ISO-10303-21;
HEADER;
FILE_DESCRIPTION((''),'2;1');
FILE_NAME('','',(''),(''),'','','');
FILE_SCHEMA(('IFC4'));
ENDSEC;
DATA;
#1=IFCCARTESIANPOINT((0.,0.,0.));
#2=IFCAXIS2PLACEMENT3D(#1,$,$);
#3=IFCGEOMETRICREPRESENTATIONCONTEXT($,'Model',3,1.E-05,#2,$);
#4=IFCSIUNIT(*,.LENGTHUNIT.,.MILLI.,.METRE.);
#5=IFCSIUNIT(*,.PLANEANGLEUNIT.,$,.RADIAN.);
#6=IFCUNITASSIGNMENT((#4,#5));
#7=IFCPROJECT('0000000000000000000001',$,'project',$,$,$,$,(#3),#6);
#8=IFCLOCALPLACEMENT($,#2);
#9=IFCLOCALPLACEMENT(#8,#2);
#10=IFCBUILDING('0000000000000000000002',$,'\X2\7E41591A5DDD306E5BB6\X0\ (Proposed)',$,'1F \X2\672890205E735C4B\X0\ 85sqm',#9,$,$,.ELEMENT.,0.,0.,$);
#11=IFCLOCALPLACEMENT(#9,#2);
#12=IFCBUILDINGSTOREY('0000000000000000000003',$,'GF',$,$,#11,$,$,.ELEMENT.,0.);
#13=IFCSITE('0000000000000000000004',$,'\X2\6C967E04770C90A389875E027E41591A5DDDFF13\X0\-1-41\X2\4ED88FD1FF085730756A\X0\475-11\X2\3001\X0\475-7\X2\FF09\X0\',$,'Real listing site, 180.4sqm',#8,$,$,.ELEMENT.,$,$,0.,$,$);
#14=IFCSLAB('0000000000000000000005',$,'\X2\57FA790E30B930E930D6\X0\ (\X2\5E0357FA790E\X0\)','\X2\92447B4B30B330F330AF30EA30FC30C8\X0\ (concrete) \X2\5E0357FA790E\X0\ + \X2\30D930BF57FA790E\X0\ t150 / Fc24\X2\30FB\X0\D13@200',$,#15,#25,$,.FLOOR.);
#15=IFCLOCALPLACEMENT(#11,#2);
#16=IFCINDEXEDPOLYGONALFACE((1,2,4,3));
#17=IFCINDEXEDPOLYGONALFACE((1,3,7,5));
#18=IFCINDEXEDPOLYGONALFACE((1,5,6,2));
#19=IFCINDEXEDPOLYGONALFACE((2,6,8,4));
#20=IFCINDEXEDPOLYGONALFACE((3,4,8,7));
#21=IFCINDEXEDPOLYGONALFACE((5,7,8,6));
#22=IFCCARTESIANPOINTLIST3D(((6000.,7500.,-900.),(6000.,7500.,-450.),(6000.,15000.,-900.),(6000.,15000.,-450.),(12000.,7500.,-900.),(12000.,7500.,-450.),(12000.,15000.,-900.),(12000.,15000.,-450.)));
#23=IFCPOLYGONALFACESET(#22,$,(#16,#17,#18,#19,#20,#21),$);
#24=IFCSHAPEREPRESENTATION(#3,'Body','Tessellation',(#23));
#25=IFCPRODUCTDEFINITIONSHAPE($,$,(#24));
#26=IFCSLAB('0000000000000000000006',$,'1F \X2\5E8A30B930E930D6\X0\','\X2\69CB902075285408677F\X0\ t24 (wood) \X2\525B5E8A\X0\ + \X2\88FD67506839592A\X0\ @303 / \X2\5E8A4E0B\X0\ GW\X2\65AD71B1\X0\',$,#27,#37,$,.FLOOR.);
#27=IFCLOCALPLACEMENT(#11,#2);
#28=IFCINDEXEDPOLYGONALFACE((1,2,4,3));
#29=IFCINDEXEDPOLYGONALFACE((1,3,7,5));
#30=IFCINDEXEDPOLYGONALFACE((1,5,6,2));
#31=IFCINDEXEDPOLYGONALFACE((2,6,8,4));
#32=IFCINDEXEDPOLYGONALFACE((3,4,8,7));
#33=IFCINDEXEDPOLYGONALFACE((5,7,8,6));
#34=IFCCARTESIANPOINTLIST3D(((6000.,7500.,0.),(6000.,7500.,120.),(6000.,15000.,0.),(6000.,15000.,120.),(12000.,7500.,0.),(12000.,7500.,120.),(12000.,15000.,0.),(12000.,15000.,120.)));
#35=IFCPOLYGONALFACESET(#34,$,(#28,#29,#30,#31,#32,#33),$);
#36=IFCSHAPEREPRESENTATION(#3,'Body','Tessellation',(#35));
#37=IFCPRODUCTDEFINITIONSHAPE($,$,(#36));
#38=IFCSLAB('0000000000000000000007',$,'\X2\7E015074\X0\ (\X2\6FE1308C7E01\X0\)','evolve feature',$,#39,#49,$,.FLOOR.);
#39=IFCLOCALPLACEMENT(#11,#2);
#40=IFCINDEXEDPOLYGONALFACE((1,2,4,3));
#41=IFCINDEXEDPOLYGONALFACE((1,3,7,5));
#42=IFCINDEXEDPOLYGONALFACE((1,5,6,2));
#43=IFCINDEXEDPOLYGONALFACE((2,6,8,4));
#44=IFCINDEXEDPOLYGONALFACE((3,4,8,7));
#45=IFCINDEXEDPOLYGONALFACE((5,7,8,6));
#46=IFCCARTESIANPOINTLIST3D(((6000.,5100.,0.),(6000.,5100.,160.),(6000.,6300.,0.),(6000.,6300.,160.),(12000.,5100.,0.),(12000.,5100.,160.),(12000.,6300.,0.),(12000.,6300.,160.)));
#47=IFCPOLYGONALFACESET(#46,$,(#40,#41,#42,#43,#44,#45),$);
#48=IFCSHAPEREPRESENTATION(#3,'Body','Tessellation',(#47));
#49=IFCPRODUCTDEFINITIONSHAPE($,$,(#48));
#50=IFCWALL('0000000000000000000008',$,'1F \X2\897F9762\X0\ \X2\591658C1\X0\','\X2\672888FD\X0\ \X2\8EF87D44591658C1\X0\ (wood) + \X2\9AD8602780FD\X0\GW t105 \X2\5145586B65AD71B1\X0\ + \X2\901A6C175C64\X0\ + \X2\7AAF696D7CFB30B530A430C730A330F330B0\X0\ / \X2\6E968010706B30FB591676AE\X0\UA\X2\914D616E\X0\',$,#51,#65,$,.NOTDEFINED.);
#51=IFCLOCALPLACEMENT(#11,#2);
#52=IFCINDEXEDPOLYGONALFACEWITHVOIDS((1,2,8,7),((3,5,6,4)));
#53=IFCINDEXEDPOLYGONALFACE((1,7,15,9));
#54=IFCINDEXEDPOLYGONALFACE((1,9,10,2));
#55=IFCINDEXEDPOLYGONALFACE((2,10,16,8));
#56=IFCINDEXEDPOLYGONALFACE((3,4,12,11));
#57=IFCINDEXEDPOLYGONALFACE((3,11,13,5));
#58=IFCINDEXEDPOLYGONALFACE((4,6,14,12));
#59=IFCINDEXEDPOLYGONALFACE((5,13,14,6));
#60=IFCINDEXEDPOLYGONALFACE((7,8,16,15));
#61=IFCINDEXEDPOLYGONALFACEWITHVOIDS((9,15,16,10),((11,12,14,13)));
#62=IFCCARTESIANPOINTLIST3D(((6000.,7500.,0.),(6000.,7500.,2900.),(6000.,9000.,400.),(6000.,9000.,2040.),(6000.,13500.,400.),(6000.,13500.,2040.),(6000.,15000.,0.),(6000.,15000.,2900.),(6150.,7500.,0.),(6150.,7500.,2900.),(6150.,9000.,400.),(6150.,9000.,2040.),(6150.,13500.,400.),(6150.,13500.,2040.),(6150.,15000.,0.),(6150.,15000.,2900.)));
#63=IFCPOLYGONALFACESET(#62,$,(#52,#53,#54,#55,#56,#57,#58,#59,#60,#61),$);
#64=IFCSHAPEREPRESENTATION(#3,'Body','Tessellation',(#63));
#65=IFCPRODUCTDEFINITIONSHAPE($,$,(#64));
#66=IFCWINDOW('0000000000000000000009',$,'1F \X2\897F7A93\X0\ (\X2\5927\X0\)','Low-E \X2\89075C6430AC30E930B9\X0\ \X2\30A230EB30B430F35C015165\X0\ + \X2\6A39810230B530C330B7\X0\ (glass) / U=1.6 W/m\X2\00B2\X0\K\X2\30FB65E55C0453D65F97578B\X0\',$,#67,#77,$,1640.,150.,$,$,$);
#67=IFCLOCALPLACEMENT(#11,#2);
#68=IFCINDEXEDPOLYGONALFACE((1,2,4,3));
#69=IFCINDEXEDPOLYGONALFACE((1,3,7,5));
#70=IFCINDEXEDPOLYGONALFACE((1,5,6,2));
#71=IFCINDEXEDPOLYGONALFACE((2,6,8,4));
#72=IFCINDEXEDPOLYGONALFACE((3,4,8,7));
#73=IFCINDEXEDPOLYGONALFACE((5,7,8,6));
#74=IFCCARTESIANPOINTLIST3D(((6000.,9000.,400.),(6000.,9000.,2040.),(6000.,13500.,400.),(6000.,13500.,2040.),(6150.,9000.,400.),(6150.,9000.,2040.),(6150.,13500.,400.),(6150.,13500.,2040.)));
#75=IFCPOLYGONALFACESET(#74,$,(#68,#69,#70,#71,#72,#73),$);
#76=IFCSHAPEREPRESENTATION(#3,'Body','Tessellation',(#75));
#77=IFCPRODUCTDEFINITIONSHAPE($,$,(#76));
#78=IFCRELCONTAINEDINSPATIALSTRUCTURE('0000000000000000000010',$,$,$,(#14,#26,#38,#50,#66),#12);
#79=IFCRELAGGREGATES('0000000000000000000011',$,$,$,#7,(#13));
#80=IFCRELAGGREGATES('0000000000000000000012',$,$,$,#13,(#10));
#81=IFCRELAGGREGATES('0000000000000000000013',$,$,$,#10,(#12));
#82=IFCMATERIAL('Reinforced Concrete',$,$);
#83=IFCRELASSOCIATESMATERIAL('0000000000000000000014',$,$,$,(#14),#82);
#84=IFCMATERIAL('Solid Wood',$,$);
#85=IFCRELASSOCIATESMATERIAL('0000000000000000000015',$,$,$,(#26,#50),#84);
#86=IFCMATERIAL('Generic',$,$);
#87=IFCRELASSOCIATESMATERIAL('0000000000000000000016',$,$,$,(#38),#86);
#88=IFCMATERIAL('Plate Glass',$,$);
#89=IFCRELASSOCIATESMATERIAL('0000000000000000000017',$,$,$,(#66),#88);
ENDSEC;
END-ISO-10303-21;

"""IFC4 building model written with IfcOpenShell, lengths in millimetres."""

from ifc_helpers import new_model, si_unit, frame, frame_2d, origin, place, context, project, spatial, rectangle, extrude, material, element, fill, save


model = new_model("IFC4")

# Units and contexts
model_context = context("Model", 3, precision=1e-05, world=origin())
ifc_project = project(units=[si_unit("LENGTHUNIT", "METRE", prefix="MILLI"), si_unit("PLANEANGLEUNIT", "RADIAN")], contexts=[model_context])

# Site, building, storey
site_placement = place(None, origin())
site = spatial("IfcSite", under=ifc_project, at=site_placement, Name="沖縄県那覇市繁多川３-1-41付近（地番475-11、475-7）", ObjectType="Real listing site, 180.4sqm", CompositionType="ELEMENT", RefElevation=0.0)
building_placement = place(site_placement, origin())
building = spatial("IfcBuilding", under=site, at=building_placement, Name="繁多川の家 (Proposed)", ObjectType="1F 木造平屋 85sqm", CompositionType="ELEMENT", ElevationOfRefHeight=0.0, ElevationOfTerrain=0.0)
storey_placement = place(building_placement, origin())
storey = spatial("IfcBuildingStorey", under=building, at=storey_placement, Name="GF", CompositionType="ELEMENT", Elevation=0.0)

# Slabs
ifc_material_1 = material(Name="Reinforced Concrete")
slab_1_placement = place(storey_placement, frame((3000.0, 3750.0, -450.0)))
element("IfcSlab", 1, at=slab_1_placement, inside=storey, material=ifc_material_1, Name="基礎スラブ (布基礎)", Description="鉄筋コンクリート (concrete) 布基礎 + ベタ基礎 t150 / Fc24・D13@200", PredefinedType="FLOOR", context=model_context, shape_type="SweptSolid", body=[
    extrude(rectangle(XDim=6000.0, YDim=7500.0, at=frame_2d((3000.0, 3750.0))), frame((3000.0, 3750.0, -450.0)), (0.0, 0.0, 1.0), 450.0),
])
ifc_material_2 = material(Name="Solid Wood")
slab_2_placement = place(storey_placement, frame((3000.0, 3750.0, 0.0)))
element("IfcSlab", 2, at=slab_2_placement, inside=storey, material=ifc_material_2, Name="1F 床スラブ", Description="構造用合板 t24 (wood) 剛床 + 製材根太 @303 / 床下 GW断熱", PredefinedType="FLOOR", context=model_context, shape_type="SweptSolid", body=[
    extrude(rectangle(XDim=6000.0, YDim=7500.0, at=frame_2d((3000.0, 3750.0))), frame((3000.0, 3750.0, 0.0)), (0.0, 0.0, 1.0), 120.0),
])
ifc_material_3 = material(Name="Generic")
slab_3_placement = place(storey_placement, frame((3000.0, 2550.0, 0.0)))
element("IfcSlab", 3, at=slab_3_placement, inside=storey, material=ifc_material_3, Name="縁側 (濡れ縁)", Description="evolve feature", PredefinedType="FLOOR", context=model_context, shape_type="SweptSolid", body=[
    extrude(rectangle(XDim=6000.0, YDim=1200.0, at=frame_2d((3000.0, 600.0))), frame((3000.0, 2550.0, 0.0)), (0.0, 0.0, 1.0), 160.0),
])

# Shared definitions
ifc_material_4 = material(Name="Plate Glass")

# Wall, opening, window
wall_1_placement = place(storey_placement, frame((3000.0, 3750.0, 0.0)))
wall_1 = element("IfcWall", 4, at=wall_1_placement, inside=storey, material=ifc_material_2, Name="1F 西面 外壁", Description="木製 軸組外壁 (wood) + 高性能GW t105 充填断熱 + 通気層 + 窯業系サイディング / 準耐火・外皮UA配慮", PredefinedType="NOTDEFINED", context=model_context, shape_type="SweptSolid", body=[
    extrude(rectangle(XDim=150.0, YDim=7500.0, at=frame_2d((75.0, 3750.0))), frame((3000.0, 3750.0, 0.0)), (0.0, 0.0, 1.0), 2900.0),
])
opening_1_placement = place(storey_placement, frame((3000.0, 4500.0, 200.0)))
opening_1 = element("IfcOpeningElement", 5, at=opening_1_placement, cuts=wall_1, PredefinedType="NOTDEFINED", context=model_context, shape_type="SweptSolid", body=[
    extrude(rectangle(XDim=150.0, YDim=4500.0, at=frame_2d((75.0, 2250.0))), frame((3000.0, 4500.0, 200.0)), (0.0, 0.0, 1.0), 1640.0),
])
window_1_placement = place(storey_placement, frame((3000.0, 4500.0, 200.0)))
window_1 = element("IfcWindow", 6, at=window_1_placement, inside=storey, material=ifc_material_4, Name="1F 西窓 (大)", Description="Low-E 複層ガラス アルゴン封入 + 樹脂サッシ (glass) / U=1.6 W/m²K・日射取得型", OverallHeight=1640.0, OverallWidth=150.0, context=model_context, shape_type="SweptSolid", body=[
    extrude(rectangle(XDim=150.0, YDim=4500.0, at=frame_2d((75.0, 2250.0))), frame((3000.0, 4500.0, 200.0)), (0.0, 0.0, 1.0), 1640.0),
])
fill(opening_1, window_1)

save(model, "model.ifc")
